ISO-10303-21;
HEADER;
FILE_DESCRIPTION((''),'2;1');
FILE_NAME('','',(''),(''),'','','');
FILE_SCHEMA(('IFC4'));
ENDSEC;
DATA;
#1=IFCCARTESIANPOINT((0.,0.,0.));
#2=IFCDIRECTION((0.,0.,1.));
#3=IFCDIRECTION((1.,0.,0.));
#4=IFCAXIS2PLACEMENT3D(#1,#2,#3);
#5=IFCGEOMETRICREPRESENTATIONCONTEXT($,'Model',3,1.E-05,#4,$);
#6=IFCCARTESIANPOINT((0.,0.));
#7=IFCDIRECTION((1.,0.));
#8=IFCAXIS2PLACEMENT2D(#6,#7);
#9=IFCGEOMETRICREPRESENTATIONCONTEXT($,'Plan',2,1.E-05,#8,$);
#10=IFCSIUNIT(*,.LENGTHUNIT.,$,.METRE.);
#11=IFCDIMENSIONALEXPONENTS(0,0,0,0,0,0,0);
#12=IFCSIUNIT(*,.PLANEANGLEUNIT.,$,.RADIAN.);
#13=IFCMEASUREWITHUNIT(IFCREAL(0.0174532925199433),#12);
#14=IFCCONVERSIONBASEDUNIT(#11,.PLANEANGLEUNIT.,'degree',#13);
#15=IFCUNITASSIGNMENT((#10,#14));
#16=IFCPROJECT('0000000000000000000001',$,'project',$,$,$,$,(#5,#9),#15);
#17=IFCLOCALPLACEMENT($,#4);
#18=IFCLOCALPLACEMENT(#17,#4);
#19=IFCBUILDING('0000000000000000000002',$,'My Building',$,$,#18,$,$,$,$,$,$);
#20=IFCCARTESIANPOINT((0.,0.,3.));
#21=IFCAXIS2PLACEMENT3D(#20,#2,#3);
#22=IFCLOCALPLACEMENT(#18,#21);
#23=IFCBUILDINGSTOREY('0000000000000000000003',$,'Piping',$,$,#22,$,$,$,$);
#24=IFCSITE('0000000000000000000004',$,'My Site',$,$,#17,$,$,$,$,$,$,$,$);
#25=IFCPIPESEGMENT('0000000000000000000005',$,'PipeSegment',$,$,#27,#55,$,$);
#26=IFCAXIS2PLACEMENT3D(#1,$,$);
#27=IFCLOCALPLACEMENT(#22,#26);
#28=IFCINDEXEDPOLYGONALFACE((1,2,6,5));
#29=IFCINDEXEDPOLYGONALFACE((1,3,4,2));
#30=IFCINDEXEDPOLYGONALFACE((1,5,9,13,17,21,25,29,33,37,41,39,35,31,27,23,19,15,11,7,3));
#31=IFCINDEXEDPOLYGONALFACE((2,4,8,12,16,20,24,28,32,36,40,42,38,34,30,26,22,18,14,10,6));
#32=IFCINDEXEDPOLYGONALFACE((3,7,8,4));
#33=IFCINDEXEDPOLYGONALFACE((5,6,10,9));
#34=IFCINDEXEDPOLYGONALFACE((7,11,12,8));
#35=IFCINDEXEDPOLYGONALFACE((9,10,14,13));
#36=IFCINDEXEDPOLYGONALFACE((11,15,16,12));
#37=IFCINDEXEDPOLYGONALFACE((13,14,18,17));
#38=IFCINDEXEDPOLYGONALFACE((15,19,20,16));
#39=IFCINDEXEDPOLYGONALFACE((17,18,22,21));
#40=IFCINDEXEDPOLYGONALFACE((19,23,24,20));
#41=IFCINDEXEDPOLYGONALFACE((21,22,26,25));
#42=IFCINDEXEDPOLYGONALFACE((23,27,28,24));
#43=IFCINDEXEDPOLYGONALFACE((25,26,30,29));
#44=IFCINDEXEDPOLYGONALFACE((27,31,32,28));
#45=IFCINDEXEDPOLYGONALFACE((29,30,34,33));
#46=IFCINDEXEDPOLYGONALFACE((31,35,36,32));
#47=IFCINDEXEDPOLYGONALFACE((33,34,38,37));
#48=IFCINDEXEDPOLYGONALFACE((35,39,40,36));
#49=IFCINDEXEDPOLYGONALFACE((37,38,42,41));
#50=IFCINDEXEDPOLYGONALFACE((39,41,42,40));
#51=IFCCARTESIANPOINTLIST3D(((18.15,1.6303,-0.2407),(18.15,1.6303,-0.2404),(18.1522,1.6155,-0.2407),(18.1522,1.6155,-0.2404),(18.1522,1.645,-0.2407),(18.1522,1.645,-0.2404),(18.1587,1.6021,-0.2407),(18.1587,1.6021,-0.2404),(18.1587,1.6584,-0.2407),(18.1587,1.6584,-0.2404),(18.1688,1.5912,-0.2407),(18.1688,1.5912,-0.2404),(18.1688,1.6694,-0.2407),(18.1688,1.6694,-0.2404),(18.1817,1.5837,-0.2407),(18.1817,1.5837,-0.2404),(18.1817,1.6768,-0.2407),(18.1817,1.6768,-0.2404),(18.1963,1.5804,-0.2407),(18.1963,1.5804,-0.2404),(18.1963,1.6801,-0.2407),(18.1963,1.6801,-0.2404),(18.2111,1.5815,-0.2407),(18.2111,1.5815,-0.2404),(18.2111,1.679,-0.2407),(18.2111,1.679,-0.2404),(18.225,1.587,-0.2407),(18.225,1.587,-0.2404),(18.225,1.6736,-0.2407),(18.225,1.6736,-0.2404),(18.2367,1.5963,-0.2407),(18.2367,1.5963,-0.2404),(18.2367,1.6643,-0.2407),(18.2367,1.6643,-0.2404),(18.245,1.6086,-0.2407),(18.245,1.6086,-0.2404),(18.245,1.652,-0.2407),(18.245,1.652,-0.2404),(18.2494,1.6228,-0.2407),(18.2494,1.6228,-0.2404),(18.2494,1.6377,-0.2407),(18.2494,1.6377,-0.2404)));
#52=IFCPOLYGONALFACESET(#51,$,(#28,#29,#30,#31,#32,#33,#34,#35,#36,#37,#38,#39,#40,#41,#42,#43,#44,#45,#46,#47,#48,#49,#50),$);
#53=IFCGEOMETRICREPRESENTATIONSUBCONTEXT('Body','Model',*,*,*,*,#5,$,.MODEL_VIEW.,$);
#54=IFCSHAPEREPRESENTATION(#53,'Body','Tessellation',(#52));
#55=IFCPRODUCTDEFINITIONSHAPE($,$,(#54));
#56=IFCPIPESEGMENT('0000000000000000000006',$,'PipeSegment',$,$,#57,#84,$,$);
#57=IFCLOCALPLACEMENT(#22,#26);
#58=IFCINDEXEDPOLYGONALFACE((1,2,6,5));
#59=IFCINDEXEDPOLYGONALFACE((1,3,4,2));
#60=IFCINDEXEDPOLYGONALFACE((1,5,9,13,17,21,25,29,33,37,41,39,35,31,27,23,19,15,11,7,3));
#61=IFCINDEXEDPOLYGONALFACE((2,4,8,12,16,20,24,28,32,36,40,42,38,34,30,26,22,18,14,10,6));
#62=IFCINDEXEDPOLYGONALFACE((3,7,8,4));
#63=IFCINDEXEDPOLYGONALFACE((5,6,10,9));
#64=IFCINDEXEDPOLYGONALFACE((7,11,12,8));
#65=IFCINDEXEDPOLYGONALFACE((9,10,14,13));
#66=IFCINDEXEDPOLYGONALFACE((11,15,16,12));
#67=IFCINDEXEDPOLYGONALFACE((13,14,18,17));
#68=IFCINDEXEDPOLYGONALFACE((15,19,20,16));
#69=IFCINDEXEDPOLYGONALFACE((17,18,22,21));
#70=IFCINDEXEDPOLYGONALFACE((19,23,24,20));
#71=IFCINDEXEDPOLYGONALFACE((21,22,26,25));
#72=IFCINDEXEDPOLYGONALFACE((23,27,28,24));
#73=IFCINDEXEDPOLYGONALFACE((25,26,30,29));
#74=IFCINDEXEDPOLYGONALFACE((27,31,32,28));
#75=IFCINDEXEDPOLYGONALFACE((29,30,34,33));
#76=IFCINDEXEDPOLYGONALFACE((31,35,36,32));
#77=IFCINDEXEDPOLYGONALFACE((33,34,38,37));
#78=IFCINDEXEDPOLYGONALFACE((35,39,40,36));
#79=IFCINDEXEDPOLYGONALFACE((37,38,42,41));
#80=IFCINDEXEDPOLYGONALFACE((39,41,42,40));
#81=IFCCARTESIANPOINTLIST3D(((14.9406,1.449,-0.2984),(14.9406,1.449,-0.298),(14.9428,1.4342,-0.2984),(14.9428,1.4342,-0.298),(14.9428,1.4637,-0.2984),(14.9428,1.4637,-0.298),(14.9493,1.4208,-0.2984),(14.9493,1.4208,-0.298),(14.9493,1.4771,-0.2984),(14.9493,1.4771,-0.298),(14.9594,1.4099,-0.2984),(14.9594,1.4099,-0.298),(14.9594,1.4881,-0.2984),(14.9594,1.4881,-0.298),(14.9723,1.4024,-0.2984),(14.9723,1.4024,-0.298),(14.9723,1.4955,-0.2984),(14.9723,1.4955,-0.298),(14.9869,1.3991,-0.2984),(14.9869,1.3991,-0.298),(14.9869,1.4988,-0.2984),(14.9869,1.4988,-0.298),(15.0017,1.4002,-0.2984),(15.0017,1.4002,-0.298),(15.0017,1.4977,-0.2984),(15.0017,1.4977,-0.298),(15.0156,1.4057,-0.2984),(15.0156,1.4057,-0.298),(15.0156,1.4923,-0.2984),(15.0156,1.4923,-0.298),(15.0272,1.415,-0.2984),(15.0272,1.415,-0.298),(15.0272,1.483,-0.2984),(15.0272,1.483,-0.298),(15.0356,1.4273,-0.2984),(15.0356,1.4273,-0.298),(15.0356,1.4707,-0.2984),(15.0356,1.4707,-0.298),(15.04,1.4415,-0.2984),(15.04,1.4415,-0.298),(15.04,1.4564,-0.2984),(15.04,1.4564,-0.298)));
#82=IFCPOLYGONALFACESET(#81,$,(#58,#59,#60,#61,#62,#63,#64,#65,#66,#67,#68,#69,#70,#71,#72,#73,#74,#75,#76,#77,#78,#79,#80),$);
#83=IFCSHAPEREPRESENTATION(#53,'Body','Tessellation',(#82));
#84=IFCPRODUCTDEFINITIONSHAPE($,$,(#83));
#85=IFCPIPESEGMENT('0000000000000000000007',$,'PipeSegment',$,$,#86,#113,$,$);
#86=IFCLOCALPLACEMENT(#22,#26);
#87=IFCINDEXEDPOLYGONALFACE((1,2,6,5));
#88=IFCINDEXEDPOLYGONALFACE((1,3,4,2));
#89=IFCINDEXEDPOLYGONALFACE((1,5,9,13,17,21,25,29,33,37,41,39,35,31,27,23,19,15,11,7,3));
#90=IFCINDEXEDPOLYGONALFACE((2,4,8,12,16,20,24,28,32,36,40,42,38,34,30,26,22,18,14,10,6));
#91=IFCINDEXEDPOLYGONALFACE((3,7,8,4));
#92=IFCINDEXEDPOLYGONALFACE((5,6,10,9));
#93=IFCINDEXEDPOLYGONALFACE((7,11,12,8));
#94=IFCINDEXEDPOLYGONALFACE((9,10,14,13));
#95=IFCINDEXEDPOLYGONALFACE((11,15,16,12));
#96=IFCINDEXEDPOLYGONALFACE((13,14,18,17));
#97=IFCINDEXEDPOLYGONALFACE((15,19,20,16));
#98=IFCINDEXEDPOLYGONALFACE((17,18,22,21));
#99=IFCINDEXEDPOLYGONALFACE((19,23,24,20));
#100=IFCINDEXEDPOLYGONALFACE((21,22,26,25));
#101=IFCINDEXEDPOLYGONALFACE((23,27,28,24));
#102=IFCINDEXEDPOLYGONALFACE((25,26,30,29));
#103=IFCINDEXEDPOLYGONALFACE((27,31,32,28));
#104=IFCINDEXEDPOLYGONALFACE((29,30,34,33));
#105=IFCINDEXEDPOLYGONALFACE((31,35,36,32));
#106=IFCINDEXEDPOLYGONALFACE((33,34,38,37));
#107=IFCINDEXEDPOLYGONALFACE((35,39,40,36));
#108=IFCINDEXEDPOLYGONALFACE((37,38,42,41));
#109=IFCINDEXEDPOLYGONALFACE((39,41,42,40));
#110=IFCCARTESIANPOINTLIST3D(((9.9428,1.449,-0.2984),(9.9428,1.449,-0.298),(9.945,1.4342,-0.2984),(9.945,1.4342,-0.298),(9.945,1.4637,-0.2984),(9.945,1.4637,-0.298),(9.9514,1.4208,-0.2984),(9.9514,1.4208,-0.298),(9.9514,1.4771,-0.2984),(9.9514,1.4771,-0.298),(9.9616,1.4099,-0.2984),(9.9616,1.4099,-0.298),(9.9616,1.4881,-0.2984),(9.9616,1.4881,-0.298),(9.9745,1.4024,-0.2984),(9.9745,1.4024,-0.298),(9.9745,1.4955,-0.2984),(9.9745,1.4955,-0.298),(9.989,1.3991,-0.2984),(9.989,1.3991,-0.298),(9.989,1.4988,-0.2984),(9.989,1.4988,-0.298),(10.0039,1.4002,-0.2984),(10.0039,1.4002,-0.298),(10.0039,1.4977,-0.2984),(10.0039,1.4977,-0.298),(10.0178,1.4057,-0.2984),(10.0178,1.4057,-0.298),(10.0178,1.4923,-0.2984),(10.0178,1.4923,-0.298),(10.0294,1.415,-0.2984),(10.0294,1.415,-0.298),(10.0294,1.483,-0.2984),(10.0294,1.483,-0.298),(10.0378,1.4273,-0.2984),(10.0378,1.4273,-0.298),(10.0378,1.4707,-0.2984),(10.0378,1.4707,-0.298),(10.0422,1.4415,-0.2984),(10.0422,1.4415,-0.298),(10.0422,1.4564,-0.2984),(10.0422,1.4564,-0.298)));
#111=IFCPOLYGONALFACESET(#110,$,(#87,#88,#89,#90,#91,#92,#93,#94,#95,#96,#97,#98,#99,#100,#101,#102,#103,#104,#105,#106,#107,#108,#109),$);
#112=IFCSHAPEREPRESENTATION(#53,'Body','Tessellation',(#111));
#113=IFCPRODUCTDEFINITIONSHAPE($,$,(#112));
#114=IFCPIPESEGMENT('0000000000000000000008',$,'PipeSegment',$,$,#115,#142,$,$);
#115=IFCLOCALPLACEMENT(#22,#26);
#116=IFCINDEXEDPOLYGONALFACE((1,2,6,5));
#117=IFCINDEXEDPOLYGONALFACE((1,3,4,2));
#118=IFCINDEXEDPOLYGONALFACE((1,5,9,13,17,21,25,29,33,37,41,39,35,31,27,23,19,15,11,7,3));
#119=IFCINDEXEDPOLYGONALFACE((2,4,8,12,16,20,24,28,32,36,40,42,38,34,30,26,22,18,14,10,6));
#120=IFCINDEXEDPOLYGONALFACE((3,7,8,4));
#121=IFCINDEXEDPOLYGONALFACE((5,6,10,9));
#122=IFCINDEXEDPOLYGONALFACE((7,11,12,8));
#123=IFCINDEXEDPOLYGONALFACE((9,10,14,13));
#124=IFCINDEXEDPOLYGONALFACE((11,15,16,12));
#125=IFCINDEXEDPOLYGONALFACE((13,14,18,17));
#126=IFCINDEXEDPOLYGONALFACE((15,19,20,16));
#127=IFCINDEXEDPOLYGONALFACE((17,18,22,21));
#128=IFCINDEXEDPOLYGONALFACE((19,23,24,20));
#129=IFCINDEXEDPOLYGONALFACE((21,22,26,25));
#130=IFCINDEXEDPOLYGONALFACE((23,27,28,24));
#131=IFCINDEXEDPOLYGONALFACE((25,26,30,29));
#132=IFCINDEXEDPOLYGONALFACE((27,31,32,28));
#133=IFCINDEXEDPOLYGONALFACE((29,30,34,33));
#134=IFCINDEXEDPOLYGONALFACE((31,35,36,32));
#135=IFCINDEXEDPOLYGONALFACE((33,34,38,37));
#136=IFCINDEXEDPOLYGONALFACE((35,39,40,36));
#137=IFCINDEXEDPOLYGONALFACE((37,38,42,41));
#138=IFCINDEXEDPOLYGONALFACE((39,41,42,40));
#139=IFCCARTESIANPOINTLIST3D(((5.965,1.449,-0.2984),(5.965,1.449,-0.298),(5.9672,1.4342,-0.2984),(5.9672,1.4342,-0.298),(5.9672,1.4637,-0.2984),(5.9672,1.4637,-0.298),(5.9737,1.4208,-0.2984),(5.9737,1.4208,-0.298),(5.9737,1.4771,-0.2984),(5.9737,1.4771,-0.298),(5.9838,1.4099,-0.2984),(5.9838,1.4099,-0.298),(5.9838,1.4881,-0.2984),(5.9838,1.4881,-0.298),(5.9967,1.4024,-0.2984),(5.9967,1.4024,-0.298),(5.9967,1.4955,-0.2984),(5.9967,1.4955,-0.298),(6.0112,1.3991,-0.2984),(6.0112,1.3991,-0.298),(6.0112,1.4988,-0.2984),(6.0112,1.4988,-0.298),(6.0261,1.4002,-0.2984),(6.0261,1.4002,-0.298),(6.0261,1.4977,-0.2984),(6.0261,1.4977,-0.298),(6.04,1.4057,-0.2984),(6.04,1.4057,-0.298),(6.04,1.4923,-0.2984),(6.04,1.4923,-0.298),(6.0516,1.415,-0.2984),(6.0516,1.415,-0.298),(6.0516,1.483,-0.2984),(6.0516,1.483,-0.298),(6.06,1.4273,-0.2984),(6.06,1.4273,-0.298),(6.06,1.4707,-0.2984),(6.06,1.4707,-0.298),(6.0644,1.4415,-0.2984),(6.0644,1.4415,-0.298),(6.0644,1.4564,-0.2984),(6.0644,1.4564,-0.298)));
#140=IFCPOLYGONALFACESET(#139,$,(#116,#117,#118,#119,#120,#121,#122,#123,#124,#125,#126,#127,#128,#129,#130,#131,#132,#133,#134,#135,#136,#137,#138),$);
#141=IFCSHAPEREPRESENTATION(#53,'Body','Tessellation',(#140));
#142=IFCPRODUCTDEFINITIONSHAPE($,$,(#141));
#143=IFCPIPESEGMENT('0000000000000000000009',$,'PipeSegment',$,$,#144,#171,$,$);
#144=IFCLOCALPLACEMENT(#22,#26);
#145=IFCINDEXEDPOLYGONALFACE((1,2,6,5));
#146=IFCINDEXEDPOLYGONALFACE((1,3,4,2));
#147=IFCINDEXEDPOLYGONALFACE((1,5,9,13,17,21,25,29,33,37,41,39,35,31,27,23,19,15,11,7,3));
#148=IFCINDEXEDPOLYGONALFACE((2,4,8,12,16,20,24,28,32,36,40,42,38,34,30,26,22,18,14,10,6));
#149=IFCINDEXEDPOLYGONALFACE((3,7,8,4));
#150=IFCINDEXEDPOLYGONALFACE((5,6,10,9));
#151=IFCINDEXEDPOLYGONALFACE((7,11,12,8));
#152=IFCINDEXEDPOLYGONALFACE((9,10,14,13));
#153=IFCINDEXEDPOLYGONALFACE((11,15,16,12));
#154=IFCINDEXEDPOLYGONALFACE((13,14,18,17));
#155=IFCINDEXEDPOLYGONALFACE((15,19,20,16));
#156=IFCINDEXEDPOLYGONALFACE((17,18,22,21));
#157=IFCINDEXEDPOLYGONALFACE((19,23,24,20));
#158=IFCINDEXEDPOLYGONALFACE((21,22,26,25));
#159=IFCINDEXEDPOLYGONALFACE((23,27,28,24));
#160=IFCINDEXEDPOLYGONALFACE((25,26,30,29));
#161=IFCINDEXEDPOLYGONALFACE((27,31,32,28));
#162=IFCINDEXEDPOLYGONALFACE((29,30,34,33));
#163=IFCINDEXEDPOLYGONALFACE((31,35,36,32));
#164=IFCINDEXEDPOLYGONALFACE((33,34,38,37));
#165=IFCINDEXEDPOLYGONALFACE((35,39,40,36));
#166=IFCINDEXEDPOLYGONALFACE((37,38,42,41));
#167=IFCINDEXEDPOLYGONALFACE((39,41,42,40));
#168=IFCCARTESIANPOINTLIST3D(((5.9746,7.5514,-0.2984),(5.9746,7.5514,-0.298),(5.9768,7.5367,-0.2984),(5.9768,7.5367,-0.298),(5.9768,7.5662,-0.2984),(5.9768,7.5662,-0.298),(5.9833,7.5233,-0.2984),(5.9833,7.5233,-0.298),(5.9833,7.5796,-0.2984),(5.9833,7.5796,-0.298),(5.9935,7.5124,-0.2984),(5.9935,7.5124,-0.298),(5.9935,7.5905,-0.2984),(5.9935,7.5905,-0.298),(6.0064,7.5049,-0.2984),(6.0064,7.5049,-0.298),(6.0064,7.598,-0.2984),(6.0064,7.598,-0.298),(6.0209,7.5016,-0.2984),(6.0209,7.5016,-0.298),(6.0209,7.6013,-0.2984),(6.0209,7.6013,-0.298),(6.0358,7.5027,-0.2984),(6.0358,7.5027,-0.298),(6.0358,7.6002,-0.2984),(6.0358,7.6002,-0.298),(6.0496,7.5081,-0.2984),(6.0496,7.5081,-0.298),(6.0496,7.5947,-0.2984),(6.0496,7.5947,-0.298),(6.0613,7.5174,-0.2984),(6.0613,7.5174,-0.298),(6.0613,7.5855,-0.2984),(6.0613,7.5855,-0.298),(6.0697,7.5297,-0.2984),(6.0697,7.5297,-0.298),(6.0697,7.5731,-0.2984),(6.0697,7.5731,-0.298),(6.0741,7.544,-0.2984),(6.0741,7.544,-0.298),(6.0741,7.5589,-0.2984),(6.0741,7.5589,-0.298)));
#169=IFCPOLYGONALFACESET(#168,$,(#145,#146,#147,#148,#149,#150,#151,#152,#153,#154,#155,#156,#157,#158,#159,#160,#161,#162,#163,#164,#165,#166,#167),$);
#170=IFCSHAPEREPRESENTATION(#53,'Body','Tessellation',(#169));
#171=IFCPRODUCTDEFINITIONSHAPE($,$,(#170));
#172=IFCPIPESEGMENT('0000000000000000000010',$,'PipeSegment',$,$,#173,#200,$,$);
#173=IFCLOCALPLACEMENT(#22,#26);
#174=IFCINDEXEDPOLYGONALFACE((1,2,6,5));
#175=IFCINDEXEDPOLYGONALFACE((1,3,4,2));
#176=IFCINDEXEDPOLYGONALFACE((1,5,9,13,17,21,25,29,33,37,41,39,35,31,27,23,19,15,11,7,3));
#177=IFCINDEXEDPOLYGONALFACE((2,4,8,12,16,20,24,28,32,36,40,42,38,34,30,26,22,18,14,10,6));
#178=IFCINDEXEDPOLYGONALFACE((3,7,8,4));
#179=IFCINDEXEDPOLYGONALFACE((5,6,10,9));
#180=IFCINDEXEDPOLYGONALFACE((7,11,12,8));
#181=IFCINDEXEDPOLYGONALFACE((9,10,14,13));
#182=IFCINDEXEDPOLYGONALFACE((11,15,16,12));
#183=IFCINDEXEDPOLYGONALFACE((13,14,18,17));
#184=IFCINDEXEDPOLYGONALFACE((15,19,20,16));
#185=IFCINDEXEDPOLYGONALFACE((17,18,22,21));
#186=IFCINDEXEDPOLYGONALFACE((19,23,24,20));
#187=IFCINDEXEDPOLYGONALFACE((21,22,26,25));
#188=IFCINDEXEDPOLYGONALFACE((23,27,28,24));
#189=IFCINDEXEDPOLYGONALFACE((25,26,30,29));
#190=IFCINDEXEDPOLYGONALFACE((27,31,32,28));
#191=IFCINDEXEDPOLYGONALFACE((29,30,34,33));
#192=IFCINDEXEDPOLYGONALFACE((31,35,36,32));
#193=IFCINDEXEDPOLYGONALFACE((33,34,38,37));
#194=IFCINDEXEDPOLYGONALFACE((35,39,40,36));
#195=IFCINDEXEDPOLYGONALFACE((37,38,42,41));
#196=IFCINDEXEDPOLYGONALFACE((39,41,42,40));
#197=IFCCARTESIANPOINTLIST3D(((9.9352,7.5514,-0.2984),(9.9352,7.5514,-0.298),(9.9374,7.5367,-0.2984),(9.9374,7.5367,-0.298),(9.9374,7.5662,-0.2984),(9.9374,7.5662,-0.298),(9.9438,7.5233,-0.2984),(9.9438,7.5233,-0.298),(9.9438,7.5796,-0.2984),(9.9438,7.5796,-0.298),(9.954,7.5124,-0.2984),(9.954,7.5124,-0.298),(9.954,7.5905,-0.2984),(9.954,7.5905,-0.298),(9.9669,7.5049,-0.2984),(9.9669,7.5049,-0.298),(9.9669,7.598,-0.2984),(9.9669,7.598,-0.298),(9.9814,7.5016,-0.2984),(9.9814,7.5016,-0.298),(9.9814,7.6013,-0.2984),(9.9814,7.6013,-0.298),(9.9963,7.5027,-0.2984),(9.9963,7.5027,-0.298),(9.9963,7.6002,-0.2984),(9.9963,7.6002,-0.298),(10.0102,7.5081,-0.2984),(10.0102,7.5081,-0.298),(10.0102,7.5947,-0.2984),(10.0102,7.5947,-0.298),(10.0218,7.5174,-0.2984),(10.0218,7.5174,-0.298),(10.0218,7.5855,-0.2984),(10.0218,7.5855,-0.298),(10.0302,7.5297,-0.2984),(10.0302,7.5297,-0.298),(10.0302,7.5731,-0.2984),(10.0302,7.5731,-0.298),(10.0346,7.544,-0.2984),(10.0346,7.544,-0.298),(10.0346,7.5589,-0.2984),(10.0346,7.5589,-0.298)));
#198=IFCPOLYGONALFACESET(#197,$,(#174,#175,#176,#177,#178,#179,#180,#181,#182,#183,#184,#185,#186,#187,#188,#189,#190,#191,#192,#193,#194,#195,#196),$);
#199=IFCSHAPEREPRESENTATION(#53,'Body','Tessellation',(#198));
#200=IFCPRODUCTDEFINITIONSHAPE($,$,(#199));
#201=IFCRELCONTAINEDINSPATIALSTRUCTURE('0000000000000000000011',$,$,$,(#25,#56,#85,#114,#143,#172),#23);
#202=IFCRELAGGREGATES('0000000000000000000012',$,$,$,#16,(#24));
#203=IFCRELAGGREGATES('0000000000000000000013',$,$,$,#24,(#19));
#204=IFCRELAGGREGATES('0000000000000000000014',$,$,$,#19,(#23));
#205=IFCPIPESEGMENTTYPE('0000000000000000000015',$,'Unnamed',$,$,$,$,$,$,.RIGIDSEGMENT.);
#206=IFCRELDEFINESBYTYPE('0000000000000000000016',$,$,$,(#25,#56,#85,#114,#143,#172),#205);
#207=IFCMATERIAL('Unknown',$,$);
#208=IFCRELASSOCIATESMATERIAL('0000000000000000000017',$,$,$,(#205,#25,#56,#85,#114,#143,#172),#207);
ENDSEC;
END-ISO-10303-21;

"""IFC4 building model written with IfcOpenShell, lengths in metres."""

from ifc_helpers import new_model, entity, si_unit, converted_unit, frame, origin_with_axes, origin_2d_with_axis, place, context, subcontext, project, spatial, circle, extrude, material, material_profile, profile_set, profile_usage, type_object, element, save


model = new_model("IFC4")

# Units and contexts
model_context = context("Model", 3, precision=1e-05, world=origin_with_axes())
plan_context = context("Plan", 2, precision=1e-05, world=origin_2d_with_axis())
body_context = subcontext(model_context, "Body", "Model", "MODEL_VIEW")
ifc_project = project(units=[si_unit("LENGTHUNIT", "METRE"), converted_unit("PLANEANGLEUNIT", "degree", entity("IfcReal", 0.0174532925199433), si_unit("PLANEANGLEUNIT", "RADIAN"), dimensions=[0, 0, 0, 0, 0, 0, 0])], contexts=[model_context, plan_context])

# Site, building, storey
site_placement = place(None, origin_with_axes())
site = spatial("IfcSite", under=ifc_project, at=site_placement, Name="My Site")
building_placement = place(site_placement, origin_with_axes())
building = spatial("IfcBuilding", under=site, at=building_placement, Name="My Building")
storey_placement = place(building_placement, frame((0.0, 0.0, 3.0), z_axis=(0.0, 0.0, 1.0), x_axis=(1.0, 0.0, 0.0)))
storey = spatial("IfcBuildingStorey", under=building, at=storey_placement, Name="Piping")

# Pipe segments
ifc_material = material(Name="Unknown")
ifc_material_profile_1 = material_profile(ifc_material, circle(Radius=0.05))
ifc_profile_set_1 = profile_set([ifc_material_profile_1])
pipe_segment_type = type_object("IfcPipeSegmentType", Name="Unnamed", PredefinedType="RIGIDSEGMENT", material=ifc_profile_set_1)
ifc_profile_usage_1 = profile_usage(ifc_profile_set_1, cardinal=5)
pipe_segment_1_placement = place(storey_placement, frame((18.2, 1.6303, -0.2404), z_axis=(0.0, 0.0, -1.0), x_axis=(-1.0, 0.0, 0.0)))
element("IfcPipeSegment", 1, at=pipe_segment_1_placement, inside=storey, type_object=pipe_segment_type, material=ifc_profile_usage_1, Name="PipeSegment", context=body_context, shape_type="SweptSolid", body=[
    extrude(circle(Radius=0.05), origin_with_axes(), (0.0, 0.0, 1.0), 0.0004),
])
ifc_profile_usage_2 = profile_usage(ifc_profile_set_1, cardinal=5)
pipe_segment_2_placement = place(storey_placement, frame((14.9906, 1.449, -0.298), z_axis=(0.0, 0.0, -1.0), x_axis=(-1.0, 0.0, 0.0)))
element("IfcPipeSegment", 2, at=pipe_segment_2_placement, inside=storey, type_object=pipe_segment_type, material=ifc_profile_usage_2, Name="PipeSegment", context=body_context, shape_type="SweptSolid", body=[
    extrude(circle(Radius=0.05), origin_with_axes(), (0.0, 0.0, 1.0), 0.0004),
])
ifc_profile_usage_3 = profile_usage(ifc_profile_set_1, cardinal=5)
pipe_segment_3_placement = place(storey_placement, frame((9.9928, 1.449, -0.298), z_axis=(0.0, 0.0, -1.0), x_axis=(-1.0, 0.0, 0.0)))
element("IfcPipeSegment", 3, at=pipe_segment_3_placement, inside=storey, type_object=pipe_segment_type, material=ifc_profile_usage_3, Name="PipeSegment", context=body_context, shape_type="SweptSolid", body=[
    extrude(circle(Radius=0.05), origin_with_axes(), (0.0, 0.0, 1.0), 0.0004),
])
ifc_profile_usage_4 = profile_usage(ifc_profile_set_1, cardinal=5)
pipe_segment_4_placement = place(storey_placement, frame((6.015, 1.449, -0.298), z_axis=(0.0, 0.0, -1.0), x_axis=(-1.0, 0.0, 0.0)))
element("IfcPipeSegment", 4, at=pipe_segment_4_placement, inside=storey, type_object=pipe_segment_type, material=ifc_profile_usage_4, Name="PipeSegment", context=body_context, shape_type="SweptSolid", body=[
    extrude(circle(Radius=0.05), origin_with_axes(), (0.0, 0.0, 1.0), 0.0004),
])
ifc_profile_usage_5 = profile_usage(ifc_profile_set_1, cardinal=5)
pipe_segment_5_placement = place(storey_placement, frame((6.0246, 7.5514, -0.298), z_axis=(0.0, 0.0, -1.0), x_axis=(-1.0, 0.0, 0.0)))
element("IfcPipeSegment", 5, at=pipe_segment_5_placement, inside=storey, type_object=pipe_segment_type, material=ifc_profile_usage_5, Name="PipeSegment", context=body_context, shape_type="SweptSolid", body=[
    extrude(circle(Radius=0.05), origin_with_axes(), (0.0, 0.0, 1.0), 0.0004),
])
ifc_profile_usage_6 = profile_usage(ifc_profile_set_1, cardinal=5)
pipe_segment_6_placement = place(storey_placement, frame((9.9852, 7.5514, -0.298), z_axis=(0.0, 0.0, -1.0), x_axis=(-1.0, 0.0, 0.0)))
element("IfcPipeSegment", 6, at=pipe_segment_6_placement, inside=storey, type_object=pipe_segment_type, material=ifc_profile_usage_6, Name="PipeSegment", context=body_context, shape_type="SweptSolid", body=[
    extrude(circle(Radius=0.05), origin_with_axes(), (0.0, 0.0, 1.0), 0.0004),
])

save(model, "model.ifc")
